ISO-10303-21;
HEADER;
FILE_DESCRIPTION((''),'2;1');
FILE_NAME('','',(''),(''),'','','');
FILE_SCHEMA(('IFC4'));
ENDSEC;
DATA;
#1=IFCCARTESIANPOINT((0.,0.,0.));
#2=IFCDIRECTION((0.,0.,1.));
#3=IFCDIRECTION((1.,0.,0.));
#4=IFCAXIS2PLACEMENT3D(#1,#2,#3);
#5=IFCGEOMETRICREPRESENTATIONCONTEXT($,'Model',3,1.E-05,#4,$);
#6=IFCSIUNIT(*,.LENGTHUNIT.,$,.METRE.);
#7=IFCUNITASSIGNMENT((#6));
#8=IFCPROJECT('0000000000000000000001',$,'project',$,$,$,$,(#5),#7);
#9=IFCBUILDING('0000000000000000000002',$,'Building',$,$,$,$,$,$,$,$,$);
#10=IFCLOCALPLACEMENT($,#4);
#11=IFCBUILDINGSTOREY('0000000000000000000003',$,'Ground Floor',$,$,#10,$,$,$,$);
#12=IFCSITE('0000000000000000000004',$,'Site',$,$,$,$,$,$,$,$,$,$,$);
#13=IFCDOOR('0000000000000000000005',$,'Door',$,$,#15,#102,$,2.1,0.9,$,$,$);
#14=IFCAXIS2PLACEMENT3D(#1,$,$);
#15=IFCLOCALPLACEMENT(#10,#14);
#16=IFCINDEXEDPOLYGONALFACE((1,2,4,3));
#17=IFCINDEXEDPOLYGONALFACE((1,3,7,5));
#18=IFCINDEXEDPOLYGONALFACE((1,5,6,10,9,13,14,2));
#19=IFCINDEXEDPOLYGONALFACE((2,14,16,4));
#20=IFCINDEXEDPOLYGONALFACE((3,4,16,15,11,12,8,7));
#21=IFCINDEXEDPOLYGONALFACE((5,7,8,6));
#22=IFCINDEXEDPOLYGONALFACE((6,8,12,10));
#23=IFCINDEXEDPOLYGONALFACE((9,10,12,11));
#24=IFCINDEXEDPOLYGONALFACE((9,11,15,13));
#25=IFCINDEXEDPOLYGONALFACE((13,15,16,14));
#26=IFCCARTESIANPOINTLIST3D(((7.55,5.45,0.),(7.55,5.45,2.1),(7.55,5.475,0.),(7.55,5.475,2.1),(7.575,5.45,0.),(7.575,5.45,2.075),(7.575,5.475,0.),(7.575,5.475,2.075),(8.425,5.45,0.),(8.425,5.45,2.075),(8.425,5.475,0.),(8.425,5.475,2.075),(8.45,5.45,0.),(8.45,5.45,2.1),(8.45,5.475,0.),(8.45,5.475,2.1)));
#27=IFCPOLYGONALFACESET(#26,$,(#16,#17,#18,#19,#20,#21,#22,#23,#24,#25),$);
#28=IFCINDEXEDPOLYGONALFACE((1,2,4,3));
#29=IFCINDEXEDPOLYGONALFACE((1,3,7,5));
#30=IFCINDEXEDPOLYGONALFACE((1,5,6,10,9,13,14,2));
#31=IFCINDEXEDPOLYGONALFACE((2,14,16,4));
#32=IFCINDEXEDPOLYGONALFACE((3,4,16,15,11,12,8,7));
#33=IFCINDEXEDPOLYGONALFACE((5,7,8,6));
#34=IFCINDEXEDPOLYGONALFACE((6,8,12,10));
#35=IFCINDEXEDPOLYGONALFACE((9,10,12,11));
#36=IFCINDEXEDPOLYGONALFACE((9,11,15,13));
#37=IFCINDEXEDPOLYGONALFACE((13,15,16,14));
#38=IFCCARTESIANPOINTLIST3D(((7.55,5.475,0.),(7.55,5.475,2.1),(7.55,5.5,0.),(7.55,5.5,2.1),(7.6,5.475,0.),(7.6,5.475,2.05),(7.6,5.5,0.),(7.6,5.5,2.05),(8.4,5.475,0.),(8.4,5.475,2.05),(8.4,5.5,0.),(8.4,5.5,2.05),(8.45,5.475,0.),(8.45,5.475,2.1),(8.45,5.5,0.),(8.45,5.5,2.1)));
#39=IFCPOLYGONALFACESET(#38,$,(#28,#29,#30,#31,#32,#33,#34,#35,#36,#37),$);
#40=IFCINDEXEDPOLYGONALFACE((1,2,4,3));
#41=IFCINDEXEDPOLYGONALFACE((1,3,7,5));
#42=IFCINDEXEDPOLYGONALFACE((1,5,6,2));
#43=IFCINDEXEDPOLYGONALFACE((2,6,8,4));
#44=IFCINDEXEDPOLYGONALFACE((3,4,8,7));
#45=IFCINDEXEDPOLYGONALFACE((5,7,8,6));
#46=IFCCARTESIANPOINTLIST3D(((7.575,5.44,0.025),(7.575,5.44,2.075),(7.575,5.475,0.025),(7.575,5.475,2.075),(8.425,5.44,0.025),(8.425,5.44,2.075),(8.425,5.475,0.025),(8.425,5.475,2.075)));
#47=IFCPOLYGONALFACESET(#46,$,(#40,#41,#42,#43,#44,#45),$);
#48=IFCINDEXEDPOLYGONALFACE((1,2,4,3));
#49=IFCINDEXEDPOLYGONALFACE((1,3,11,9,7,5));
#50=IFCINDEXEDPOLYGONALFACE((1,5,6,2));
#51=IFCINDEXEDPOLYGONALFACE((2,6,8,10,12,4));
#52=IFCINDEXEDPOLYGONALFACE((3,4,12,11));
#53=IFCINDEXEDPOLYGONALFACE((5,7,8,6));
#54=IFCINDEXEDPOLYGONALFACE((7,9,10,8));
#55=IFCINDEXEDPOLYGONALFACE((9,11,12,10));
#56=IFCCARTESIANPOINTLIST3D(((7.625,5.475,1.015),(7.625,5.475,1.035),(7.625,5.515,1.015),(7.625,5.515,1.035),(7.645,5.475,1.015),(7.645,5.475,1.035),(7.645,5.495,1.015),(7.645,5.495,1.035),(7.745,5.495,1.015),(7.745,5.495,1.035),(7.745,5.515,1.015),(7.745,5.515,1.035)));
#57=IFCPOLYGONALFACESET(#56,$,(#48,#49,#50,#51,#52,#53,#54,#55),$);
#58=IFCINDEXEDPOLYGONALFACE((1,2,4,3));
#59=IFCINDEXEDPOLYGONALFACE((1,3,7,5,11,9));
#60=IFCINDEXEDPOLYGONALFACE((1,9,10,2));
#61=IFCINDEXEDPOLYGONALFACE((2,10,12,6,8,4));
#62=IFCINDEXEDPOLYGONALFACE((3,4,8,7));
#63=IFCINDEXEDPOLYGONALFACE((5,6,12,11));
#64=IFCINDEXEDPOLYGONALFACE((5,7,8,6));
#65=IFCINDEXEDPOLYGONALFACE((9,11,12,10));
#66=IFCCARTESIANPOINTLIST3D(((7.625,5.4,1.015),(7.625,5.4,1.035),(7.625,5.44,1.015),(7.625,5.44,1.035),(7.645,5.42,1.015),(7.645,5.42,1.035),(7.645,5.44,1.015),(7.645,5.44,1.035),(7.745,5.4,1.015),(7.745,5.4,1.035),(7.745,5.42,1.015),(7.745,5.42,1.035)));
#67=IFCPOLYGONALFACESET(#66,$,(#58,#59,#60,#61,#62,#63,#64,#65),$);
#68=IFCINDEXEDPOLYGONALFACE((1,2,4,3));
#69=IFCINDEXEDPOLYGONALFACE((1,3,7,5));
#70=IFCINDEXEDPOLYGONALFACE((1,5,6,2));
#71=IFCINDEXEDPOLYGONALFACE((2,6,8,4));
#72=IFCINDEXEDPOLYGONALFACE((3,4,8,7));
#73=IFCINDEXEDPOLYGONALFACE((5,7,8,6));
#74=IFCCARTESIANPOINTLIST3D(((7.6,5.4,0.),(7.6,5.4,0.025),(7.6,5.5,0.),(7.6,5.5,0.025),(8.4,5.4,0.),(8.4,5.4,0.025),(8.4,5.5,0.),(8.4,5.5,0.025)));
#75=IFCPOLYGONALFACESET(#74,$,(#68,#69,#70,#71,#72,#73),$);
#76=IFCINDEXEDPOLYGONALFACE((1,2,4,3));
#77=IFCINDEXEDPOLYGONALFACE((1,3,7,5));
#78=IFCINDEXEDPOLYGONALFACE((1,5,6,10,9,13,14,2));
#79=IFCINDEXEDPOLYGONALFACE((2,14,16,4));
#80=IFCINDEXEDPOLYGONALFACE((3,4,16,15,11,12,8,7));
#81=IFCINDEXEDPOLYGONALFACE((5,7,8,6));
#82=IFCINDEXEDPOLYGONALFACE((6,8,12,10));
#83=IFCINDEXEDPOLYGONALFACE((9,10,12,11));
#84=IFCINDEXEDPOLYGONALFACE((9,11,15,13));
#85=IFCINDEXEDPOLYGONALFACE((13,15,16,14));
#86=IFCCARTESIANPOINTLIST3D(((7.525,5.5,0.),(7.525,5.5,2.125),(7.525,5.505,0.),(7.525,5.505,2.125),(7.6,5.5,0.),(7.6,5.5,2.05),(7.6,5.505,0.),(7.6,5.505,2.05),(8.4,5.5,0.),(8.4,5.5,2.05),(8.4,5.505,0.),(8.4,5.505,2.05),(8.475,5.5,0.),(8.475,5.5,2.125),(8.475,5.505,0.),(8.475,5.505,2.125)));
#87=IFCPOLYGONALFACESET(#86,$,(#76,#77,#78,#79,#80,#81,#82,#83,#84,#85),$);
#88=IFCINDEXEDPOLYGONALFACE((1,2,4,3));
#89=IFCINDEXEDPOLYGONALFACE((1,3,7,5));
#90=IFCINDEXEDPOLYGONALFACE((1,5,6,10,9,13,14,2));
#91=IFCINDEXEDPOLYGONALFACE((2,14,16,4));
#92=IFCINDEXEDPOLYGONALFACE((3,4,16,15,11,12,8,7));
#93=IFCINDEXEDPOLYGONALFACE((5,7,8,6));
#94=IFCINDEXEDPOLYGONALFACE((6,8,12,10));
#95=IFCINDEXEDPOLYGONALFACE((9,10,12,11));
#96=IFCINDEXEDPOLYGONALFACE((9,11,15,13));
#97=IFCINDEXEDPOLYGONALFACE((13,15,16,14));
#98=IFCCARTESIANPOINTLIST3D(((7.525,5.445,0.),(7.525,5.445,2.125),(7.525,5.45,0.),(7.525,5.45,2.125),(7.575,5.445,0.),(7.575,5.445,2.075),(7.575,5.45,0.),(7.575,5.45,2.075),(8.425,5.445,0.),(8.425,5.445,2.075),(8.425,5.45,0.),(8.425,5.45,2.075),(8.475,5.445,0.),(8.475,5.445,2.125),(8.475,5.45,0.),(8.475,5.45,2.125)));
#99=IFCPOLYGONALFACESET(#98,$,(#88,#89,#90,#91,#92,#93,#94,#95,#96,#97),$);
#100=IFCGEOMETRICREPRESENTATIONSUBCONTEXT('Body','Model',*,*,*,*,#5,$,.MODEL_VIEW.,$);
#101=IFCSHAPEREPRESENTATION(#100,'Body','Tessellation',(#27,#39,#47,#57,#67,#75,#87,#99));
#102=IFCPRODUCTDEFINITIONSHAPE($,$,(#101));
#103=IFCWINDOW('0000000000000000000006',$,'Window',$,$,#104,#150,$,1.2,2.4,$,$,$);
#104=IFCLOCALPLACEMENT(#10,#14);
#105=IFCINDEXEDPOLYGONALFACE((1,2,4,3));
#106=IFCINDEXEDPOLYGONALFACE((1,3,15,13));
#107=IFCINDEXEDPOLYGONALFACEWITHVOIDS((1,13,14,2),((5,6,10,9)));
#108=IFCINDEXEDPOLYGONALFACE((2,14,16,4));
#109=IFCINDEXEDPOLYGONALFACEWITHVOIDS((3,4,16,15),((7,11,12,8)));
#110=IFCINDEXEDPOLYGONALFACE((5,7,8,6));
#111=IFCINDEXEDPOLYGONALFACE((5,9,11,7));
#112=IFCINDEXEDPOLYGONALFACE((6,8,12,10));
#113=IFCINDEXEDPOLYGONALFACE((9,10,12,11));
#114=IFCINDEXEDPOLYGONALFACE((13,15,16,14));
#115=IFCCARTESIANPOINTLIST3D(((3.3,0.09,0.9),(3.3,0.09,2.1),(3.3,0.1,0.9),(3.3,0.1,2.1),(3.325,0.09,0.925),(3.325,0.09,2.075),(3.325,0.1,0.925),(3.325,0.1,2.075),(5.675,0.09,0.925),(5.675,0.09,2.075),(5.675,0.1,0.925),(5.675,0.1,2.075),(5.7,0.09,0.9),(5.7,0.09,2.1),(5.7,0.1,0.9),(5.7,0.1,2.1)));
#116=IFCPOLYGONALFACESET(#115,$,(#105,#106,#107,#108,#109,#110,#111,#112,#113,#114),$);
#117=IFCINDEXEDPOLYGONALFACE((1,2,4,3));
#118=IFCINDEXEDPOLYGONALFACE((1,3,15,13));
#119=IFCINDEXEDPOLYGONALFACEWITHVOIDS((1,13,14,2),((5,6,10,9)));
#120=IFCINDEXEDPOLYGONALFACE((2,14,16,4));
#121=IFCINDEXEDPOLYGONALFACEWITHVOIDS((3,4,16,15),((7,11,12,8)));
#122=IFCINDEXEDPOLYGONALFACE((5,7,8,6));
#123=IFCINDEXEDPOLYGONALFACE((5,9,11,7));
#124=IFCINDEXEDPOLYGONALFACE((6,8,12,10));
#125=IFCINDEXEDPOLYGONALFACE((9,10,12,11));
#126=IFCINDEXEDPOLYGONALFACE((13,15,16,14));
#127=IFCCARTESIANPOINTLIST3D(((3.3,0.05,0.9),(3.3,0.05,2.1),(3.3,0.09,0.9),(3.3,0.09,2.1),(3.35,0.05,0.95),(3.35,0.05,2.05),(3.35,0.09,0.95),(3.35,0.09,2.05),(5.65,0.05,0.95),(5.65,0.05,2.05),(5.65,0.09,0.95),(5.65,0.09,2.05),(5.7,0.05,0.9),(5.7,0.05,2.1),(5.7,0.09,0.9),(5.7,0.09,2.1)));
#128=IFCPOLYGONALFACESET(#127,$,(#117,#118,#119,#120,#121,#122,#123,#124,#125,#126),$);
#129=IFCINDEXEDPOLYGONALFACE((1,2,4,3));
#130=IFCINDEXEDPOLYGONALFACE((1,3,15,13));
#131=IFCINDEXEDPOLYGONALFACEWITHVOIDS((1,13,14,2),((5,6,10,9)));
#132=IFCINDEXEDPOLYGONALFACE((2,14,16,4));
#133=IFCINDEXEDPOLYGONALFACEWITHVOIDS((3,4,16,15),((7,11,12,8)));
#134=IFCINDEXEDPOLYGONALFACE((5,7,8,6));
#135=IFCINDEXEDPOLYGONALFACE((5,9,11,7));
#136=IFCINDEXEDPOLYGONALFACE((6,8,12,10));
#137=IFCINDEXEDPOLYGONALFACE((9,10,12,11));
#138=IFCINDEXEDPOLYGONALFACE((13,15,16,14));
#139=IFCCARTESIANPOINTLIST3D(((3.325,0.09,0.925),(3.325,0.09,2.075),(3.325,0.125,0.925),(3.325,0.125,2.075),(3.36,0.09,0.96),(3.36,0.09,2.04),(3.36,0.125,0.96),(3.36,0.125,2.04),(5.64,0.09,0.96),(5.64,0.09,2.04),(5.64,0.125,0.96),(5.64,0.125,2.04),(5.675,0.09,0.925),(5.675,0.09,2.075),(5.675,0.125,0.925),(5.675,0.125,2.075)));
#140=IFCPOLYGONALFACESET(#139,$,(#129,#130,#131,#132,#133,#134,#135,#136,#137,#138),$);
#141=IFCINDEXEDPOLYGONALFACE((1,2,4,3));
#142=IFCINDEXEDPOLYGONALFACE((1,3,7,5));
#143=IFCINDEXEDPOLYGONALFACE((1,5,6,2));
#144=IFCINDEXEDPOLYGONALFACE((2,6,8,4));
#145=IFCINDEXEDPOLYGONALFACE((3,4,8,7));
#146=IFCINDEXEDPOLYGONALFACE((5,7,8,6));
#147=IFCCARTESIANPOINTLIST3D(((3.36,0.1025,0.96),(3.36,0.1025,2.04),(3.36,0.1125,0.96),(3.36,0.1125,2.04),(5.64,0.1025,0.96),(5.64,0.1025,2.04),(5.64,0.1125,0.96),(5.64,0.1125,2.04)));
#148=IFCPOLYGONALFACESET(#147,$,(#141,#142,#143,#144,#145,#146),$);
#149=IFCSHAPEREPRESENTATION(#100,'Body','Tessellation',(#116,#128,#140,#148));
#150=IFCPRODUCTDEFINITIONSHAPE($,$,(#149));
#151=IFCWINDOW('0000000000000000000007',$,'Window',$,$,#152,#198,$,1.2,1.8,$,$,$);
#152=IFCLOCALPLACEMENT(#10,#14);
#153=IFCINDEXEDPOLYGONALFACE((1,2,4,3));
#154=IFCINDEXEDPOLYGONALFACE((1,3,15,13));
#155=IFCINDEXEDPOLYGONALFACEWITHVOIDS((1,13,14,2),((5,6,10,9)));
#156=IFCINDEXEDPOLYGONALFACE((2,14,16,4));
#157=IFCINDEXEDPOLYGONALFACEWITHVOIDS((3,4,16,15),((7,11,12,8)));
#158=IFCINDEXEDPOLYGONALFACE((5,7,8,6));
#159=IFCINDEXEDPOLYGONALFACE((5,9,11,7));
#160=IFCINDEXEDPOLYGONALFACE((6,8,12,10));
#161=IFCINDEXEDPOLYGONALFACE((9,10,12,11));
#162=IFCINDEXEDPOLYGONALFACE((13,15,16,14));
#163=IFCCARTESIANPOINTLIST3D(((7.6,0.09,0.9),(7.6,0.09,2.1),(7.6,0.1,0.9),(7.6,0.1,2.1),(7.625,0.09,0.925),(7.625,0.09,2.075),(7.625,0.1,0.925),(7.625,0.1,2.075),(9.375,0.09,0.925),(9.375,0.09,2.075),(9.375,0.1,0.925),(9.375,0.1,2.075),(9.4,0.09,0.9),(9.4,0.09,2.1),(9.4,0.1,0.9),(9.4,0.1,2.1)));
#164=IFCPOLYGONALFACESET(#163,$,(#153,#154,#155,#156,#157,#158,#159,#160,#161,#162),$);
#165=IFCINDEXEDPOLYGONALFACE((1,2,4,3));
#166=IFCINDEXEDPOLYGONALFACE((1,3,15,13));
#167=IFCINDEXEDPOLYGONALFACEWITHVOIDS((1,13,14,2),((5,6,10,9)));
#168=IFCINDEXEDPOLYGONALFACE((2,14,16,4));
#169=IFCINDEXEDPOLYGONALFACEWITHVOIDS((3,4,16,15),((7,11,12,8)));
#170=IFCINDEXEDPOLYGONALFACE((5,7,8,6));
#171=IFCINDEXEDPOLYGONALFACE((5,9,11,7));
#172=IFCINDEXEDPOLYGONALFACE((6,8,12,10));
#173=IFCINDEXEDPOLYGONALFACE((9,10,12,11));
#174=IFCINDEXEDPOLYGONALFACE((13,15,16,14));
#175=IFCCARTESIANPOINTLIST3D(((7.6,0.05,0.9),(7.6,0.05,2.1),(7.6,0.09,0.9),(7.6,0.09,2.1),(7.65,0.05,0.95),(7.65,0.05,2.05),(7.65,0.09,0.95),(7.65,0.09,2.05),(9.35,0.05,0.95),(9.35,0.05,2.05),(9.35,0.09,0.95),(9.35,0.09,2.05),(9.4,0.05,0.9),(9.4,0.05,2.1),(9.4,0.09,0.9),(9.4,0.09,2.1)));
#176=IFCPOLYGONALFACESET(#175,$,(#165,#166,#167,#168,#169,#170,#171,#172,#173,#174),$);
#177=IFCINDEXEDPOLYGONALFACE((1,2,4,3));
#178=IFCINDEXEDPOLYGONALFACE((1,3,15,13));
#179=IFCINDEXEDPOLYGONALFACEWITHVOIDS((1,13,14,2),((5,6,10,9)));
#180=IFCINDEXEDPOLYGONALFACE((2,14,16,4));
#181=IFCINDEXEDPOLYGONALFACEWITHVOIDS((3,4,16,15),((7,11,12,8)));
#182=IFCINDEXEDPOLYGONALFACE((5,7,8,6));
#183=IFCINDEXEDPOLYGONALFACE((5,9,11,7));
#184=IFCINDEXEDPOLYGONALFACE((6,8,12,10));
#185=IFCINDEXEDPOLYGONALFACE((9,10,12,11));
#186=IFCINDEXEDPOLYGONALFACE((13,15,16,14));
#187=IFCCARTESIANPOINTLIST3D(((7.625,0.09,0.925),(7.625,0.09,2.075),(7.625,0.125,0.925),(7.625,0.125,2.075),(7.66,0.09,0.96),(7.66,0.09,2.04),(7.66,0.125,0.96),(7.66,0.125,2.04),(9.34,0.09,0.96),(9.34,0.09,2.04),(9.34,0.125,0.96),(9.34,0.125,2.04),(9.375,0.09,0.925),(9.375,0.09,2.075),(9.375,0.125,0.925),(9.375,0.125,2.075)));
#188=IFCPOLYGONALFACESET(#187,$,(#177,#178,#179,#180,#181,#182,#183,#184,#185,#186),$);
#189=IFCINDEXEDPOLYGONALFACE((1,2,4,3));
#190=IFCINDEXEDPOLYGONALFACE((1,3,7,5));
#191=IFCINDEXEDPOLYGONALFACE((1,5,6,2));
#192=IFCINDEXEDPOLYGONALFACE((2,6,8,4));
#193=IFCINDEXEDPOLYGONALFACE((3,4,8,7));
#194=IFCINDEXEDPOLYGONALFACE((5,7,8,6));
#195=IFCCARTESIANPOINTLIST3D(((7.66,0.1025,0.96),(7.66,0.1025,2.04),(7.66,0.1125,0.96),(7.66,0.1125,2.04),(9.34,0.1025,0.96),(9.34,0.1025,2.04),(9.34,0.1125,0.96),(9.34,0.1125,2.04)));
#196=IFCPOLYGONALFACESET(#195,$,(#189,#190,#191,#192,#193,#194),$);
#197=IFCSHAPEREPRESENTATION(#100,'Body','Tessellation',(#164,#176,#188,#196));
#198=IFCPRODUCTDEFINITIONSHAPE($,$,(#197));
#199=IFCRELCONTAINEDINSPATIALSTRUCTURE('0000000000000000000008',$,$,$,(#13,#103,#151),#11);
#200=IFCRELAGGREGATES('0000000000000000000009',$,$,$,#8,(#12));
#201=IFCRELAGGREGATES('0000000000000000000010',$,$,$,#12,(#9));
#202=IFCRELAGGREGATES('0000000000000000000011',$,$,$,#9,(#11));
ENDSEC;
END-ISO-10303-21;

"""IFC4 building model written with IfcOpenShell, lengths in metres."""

from ifc_helpers import new_model, si_unit, frame, origin_with_axes, place, context, subcontext, project, spatial, line, indexed_curve, outline, extrude, element, save


model = new_model("IFC4")

# Units and contexts
model_context = context("Model", 3, precision=1e-05, world=origin_with_axes())
body_context = subcontext(model_context, "Body", "Model", "MODEL_VIEW")
ifc_project = project(units=[si_unit("LENGTHUNIT", "METRE")], contexts=[model_context])

# Site, building, storey
site = spatial("IfcSite", under=ifc_project, Name="Site")
building = spatial("IfcBuilding", under=site, Name="Building")
storey_placement = place(None, origin_with_axes())
storey = spatial("IfcBuildingStorey", under=building, at=storey_placement, Name="Ground Floor")

# Door
door_1_placement = place(storey_placement, frame((8.45, 5.5, 0.0), z_axis=(0.0, 0.0, 1.0), x_axis=(-1.0, 0.0, 0.0)))
element("IfcDoor", 1, at=door_1_placement, inside=storey, Name="Door", OverallHeight=2.1, OverallWidth=0.9, context=body_context, shape_type="SweptSolid", body=[
    extrude(outline(indexed_curve([(0.0, 0.0), (0.0, 2.1), (0.9, 2.1), (0.9, 0.0), (0.875, 0.0), (0.875, 2.075), (0.025, 2.075), (0.025, 0.0)], segments=[line(1, 2, 3, 4, 5, 6, 7, 8, 1)])), frame((0.0, 0.025, 0.0), z_axis=(0.0, -1.0, 0.0), x_axis=(1.0, 0.0, 0.0)), (0.0, 0.0, -1.0), 0.025),
    extrude(outline(indexed_curve([(0.0, 0.0), (0.0, 2.1), (0.9, 2.1), (0.9, 0.0), (0.85, 0.0), (0.85, 2.05), (0.05, 2.05), (0.05, 0.0)], segments=[line(1, 2, 3, 4, 5, 6, 7, 8, 1)])), frame((0.0, 0.0, 0.0), z_axis=(0.0, -1.0, 0.0), x_axis=(1.0, 0.0, 0.0)), (0.0, 0.0, -1.0), 0.025),
    extrude(outline(indexed_curve([(0.0, 0.0), (0.85, 0.0), (0.85, 0.035), (0.0, 0.035)], segments=[line(1, 2, 3, 4, 1)])), frame((0.025, 0.025, 0.025), z_axis=(0.0, 0.0, 1.0), x_axis=(1.0, 0.0, 0.0)), (0.0, 0.0, 1.0), 2.05),
    extrude(outline(indexed_curve([(0.0, 0.0), (0.0, -0.04), (-0.12, -0.04), (-0.12, -0.02), (-0.02, -0.02), (-0.02, 0.0)], segments=[line(1, 2, 3, 4, 5, 6, 1)])), frame((0.825, 0.025, 1.015), z_axis=(0.0, 0.0, 1.0), x_axis=(1.0, 0.0, 0.0)), (0.0, 0.0, 1.0), 0.02),
    extrude(outline(indexed_curve([(0.0, 0.0), (0.0, 0.04), (-0.12, 0.04), (-0.12, 0.02), (-0.02, 0.02), (-0.02, 0.0)], segments=[line(1, 2, 3, 4, 5, 6, 1)])), frame((0.825, 0.06, 1.015), z_axis=(0.0, 0.0, 1.0), x_axis=(1.0, 0.0, 0.0)), (0.0, 0.0, 1.0), 0.02),
    extrude(outline(indexed_curve([(0.0, 0.0), (0.8, 0.0), (0.8, 0.1), (0.0, 0.1)], segments=[line(1, 2, 3, 4, 1)])), frame((0.05, 0.0, 0.0), z_axis=(0.0, 0.0, 1.0), x_axis=(1.0, 0.0, 0.0)), (0.0, 0.0, 1.0), 0.025),
    extrude(outline(indexed_curve([(0.0, 0.0), (0.0, 2.125), (0.95, 2.125), (0.95, 0.0), (0.875, 0.0), (0.875, 2.05), (0.075, 2.05), (0.075, 0.0)], segments=[line(1, 2, 3, 4, 5, 6, 7, 8, 1)])), frame((-0.025, -0.005, 0.0), z_axis=(0.0, -1.0, 0.0), x_axis=(1.0, 0.0, 0.0)), (0.0, 0.0, -1.0), 0.005),
    extrude(outline(indexed_curve([(0.0, 0.0), (0.0, 2.125), (0.95, 2.125), (0.95, 0.0), (0.9, 0.0), (0.9, 2.075), (0.05, 2.075), (0.05, 0.0)], segments=[line(1, 2, 3, 4, 5, 6, 7, 8, 1)])), frame((-0.025, 0.05, 0.0), z_axis=(0.0, -1.0, 0.0), x_axis=(1.0, 0.0, 0.0)), (0.0, 0.0, -1.0), 0.005),
])

# Windows
window_1_placement = place(storey_placement, frame((3.3, 0.0, 0.9), z_axis=(0.0, 0.0, 1.0), x_axis=(1.0, 0.0, 0.0)))
element("IfcWindow", 2, at=window_1_placement, inside=storey, Name="Window", OverallHeight=1.2, OverallWidth=2.4, context=body_context, shape_type="SweptSolid", body=[
    extrude(outline(indexed_curve([(0.0, 0.0), (2.4, 0.0), (2.4, 1.2), (0.0, 1.2)], segments=[line(1, 2, 3, 4, 1)]), holes=[indexed_curve([(0.025, 0.025), (2.375, 0.025), (2.375, 1.175), (0.025, 1.175)], segments=[line(1, 2, 3, 4, 1)])]), frame((0.0, 0.09, 0.0), z_axis=(0.0, -1.0, 0.0), x_axis=(1.0, 0.0, 0.0)), (0.0, 0.0, -1.0), 0.01),
    extrude(outline(indexed_curve([(0.0, 0.0), (2.4, 0.0), (2.4, 1.2), (0.0, 1.2)], segments=[line(1, 2, 3, 4, 1)]), holes=[indexed_curve([(0.05, 0.05), (2.35, 0.05), (2.35, 1.15), (0.05, 1.15)], segments=[line(1, 2, 3, 4, 1)])]), frame((0.0, 0.05, 0.0), z_axis=(0.0, -1.0, 0.0), x_axis=(1.0, 0.0, 0.0)), (0.0, 0.0, -1.0), 0.04),
    extrude(outline(indexed_curve([(0.0, 0.0), (2.35, 0.0), (2.35, 1.15), (0.0, 1.15)], segments=[line(1, 2, 3, 4, 1)]), holes=[indexed_curve([(0.035, 0.035), (2.315, 0.035), (2.315, 1.115), (0.035, 1.115)], segments=[line(1, 2, 3, 4, 1)])]), frame((0.025, 0.09, 0.025), z_axis=(0.0, -1.0, 0.0), x_axis=(1.0, 0.0, 0.0)), (0.0, 0.0, -1.0), 0.035),
    extrude(outline(indexed_curve([(0.035, 0.035), (2.315, 0.035), (2.315, 1.115), (0.035, 1.115)], segments=[line(1, 2, 3, 4, 1)])), frame((0.025, 0.1025, 0.025), z_axis=(0.0, -1.0, 0.0), x_axis=(1.0, 0.0, 0.0)), (0.0, 0.0, -1.0), 0.01),
])
window_2_placement = place(storey_placement, frame((7.6, 0.0, 0.9), z_axis=(0.0, 0.0, 1.0), x_axis=(1.0, 0.0, 0.0)))
element("IfcWindow", 3, at=window_2_placement, inside=storey, Name="Window", OverallHeight=1.2, OverallWidth=1.8, context=body_context, shape_type="SweptSolid", body=[
    extrude(outline(indexed_curve([(0.0, 0.0), (1.8, 0.0), (1.8, 1.2), (0.0, 1.2)], segments=[line(1, 2, 3, 4, 1)]), holes=[indexed_curve([(0.025, 0.025), (1.775, 0.025), (1.775, 1.175), (0.025, 1.175)], segments=[line(1, 2, 3, 4, 1)])]), frame((0.0, 0.09, 0.0), z_axis=(0.0, -1.0, 0.0), x_axis=(1.0, 0.0, 0.0)), (0.0, 0.0, -1.0), 0.01),
    extrude(outline(indexed_curve([(0.0, 0.0), (1.8, 0.0), (1.8, 1.2), (0.0, 1.2)], segments=[line(1, 2, 3, 4, 1)]), holes=[indexed_curve([(0.05, 0.05), (1.75, 0.05), (1.75, 1.15), (0.05, 1.15)], segments=[line(1, 2, 3, 4, 1)])]), frame((0.0, 0.05, 0.0), z_axis=(0.0, -1.0, 0.0), x_axis=(1.0, 0.0, 0.0)), (0.0, 0.0, -1.0), 0.04),
    extrude(outline(indexed_curve([(0.0, 0.0), (1.75, 0.0), (1.75, 1.15), (0.0, 1.15)], segments=[line(1, 2, 3, 4, 1)]), holes=[indexed_curve([(0.035, 0.035), (1.715, 0.035), (1.715, 1.115), (0.035, 1.115)], segments=[line(1, 2, 3, 4, 1)])]), frame((0.025, 0.09, 0.025), z_axis=(0.0, -1.0, 0.0), x_axis=(1.0, 0.0, 0.0)), (0.0, 0.0, -1.0), 0.035),
    extrude(outline(indexed_curve([(0.035, 0.035), (1.715, 0.035), (1.715, 1.115), (0.035, 1.115)], segments=[line(1, 2, 3, 4, 1)])), frame((0.025, 0.1025, 0.025), z_axis=(0.0, -1.0, 0.0), x_axis=(1.0, 0.0, 0.0)), (0.0, 0.0, -1.0), 0.01),
])

save(model, "model.ifc")
